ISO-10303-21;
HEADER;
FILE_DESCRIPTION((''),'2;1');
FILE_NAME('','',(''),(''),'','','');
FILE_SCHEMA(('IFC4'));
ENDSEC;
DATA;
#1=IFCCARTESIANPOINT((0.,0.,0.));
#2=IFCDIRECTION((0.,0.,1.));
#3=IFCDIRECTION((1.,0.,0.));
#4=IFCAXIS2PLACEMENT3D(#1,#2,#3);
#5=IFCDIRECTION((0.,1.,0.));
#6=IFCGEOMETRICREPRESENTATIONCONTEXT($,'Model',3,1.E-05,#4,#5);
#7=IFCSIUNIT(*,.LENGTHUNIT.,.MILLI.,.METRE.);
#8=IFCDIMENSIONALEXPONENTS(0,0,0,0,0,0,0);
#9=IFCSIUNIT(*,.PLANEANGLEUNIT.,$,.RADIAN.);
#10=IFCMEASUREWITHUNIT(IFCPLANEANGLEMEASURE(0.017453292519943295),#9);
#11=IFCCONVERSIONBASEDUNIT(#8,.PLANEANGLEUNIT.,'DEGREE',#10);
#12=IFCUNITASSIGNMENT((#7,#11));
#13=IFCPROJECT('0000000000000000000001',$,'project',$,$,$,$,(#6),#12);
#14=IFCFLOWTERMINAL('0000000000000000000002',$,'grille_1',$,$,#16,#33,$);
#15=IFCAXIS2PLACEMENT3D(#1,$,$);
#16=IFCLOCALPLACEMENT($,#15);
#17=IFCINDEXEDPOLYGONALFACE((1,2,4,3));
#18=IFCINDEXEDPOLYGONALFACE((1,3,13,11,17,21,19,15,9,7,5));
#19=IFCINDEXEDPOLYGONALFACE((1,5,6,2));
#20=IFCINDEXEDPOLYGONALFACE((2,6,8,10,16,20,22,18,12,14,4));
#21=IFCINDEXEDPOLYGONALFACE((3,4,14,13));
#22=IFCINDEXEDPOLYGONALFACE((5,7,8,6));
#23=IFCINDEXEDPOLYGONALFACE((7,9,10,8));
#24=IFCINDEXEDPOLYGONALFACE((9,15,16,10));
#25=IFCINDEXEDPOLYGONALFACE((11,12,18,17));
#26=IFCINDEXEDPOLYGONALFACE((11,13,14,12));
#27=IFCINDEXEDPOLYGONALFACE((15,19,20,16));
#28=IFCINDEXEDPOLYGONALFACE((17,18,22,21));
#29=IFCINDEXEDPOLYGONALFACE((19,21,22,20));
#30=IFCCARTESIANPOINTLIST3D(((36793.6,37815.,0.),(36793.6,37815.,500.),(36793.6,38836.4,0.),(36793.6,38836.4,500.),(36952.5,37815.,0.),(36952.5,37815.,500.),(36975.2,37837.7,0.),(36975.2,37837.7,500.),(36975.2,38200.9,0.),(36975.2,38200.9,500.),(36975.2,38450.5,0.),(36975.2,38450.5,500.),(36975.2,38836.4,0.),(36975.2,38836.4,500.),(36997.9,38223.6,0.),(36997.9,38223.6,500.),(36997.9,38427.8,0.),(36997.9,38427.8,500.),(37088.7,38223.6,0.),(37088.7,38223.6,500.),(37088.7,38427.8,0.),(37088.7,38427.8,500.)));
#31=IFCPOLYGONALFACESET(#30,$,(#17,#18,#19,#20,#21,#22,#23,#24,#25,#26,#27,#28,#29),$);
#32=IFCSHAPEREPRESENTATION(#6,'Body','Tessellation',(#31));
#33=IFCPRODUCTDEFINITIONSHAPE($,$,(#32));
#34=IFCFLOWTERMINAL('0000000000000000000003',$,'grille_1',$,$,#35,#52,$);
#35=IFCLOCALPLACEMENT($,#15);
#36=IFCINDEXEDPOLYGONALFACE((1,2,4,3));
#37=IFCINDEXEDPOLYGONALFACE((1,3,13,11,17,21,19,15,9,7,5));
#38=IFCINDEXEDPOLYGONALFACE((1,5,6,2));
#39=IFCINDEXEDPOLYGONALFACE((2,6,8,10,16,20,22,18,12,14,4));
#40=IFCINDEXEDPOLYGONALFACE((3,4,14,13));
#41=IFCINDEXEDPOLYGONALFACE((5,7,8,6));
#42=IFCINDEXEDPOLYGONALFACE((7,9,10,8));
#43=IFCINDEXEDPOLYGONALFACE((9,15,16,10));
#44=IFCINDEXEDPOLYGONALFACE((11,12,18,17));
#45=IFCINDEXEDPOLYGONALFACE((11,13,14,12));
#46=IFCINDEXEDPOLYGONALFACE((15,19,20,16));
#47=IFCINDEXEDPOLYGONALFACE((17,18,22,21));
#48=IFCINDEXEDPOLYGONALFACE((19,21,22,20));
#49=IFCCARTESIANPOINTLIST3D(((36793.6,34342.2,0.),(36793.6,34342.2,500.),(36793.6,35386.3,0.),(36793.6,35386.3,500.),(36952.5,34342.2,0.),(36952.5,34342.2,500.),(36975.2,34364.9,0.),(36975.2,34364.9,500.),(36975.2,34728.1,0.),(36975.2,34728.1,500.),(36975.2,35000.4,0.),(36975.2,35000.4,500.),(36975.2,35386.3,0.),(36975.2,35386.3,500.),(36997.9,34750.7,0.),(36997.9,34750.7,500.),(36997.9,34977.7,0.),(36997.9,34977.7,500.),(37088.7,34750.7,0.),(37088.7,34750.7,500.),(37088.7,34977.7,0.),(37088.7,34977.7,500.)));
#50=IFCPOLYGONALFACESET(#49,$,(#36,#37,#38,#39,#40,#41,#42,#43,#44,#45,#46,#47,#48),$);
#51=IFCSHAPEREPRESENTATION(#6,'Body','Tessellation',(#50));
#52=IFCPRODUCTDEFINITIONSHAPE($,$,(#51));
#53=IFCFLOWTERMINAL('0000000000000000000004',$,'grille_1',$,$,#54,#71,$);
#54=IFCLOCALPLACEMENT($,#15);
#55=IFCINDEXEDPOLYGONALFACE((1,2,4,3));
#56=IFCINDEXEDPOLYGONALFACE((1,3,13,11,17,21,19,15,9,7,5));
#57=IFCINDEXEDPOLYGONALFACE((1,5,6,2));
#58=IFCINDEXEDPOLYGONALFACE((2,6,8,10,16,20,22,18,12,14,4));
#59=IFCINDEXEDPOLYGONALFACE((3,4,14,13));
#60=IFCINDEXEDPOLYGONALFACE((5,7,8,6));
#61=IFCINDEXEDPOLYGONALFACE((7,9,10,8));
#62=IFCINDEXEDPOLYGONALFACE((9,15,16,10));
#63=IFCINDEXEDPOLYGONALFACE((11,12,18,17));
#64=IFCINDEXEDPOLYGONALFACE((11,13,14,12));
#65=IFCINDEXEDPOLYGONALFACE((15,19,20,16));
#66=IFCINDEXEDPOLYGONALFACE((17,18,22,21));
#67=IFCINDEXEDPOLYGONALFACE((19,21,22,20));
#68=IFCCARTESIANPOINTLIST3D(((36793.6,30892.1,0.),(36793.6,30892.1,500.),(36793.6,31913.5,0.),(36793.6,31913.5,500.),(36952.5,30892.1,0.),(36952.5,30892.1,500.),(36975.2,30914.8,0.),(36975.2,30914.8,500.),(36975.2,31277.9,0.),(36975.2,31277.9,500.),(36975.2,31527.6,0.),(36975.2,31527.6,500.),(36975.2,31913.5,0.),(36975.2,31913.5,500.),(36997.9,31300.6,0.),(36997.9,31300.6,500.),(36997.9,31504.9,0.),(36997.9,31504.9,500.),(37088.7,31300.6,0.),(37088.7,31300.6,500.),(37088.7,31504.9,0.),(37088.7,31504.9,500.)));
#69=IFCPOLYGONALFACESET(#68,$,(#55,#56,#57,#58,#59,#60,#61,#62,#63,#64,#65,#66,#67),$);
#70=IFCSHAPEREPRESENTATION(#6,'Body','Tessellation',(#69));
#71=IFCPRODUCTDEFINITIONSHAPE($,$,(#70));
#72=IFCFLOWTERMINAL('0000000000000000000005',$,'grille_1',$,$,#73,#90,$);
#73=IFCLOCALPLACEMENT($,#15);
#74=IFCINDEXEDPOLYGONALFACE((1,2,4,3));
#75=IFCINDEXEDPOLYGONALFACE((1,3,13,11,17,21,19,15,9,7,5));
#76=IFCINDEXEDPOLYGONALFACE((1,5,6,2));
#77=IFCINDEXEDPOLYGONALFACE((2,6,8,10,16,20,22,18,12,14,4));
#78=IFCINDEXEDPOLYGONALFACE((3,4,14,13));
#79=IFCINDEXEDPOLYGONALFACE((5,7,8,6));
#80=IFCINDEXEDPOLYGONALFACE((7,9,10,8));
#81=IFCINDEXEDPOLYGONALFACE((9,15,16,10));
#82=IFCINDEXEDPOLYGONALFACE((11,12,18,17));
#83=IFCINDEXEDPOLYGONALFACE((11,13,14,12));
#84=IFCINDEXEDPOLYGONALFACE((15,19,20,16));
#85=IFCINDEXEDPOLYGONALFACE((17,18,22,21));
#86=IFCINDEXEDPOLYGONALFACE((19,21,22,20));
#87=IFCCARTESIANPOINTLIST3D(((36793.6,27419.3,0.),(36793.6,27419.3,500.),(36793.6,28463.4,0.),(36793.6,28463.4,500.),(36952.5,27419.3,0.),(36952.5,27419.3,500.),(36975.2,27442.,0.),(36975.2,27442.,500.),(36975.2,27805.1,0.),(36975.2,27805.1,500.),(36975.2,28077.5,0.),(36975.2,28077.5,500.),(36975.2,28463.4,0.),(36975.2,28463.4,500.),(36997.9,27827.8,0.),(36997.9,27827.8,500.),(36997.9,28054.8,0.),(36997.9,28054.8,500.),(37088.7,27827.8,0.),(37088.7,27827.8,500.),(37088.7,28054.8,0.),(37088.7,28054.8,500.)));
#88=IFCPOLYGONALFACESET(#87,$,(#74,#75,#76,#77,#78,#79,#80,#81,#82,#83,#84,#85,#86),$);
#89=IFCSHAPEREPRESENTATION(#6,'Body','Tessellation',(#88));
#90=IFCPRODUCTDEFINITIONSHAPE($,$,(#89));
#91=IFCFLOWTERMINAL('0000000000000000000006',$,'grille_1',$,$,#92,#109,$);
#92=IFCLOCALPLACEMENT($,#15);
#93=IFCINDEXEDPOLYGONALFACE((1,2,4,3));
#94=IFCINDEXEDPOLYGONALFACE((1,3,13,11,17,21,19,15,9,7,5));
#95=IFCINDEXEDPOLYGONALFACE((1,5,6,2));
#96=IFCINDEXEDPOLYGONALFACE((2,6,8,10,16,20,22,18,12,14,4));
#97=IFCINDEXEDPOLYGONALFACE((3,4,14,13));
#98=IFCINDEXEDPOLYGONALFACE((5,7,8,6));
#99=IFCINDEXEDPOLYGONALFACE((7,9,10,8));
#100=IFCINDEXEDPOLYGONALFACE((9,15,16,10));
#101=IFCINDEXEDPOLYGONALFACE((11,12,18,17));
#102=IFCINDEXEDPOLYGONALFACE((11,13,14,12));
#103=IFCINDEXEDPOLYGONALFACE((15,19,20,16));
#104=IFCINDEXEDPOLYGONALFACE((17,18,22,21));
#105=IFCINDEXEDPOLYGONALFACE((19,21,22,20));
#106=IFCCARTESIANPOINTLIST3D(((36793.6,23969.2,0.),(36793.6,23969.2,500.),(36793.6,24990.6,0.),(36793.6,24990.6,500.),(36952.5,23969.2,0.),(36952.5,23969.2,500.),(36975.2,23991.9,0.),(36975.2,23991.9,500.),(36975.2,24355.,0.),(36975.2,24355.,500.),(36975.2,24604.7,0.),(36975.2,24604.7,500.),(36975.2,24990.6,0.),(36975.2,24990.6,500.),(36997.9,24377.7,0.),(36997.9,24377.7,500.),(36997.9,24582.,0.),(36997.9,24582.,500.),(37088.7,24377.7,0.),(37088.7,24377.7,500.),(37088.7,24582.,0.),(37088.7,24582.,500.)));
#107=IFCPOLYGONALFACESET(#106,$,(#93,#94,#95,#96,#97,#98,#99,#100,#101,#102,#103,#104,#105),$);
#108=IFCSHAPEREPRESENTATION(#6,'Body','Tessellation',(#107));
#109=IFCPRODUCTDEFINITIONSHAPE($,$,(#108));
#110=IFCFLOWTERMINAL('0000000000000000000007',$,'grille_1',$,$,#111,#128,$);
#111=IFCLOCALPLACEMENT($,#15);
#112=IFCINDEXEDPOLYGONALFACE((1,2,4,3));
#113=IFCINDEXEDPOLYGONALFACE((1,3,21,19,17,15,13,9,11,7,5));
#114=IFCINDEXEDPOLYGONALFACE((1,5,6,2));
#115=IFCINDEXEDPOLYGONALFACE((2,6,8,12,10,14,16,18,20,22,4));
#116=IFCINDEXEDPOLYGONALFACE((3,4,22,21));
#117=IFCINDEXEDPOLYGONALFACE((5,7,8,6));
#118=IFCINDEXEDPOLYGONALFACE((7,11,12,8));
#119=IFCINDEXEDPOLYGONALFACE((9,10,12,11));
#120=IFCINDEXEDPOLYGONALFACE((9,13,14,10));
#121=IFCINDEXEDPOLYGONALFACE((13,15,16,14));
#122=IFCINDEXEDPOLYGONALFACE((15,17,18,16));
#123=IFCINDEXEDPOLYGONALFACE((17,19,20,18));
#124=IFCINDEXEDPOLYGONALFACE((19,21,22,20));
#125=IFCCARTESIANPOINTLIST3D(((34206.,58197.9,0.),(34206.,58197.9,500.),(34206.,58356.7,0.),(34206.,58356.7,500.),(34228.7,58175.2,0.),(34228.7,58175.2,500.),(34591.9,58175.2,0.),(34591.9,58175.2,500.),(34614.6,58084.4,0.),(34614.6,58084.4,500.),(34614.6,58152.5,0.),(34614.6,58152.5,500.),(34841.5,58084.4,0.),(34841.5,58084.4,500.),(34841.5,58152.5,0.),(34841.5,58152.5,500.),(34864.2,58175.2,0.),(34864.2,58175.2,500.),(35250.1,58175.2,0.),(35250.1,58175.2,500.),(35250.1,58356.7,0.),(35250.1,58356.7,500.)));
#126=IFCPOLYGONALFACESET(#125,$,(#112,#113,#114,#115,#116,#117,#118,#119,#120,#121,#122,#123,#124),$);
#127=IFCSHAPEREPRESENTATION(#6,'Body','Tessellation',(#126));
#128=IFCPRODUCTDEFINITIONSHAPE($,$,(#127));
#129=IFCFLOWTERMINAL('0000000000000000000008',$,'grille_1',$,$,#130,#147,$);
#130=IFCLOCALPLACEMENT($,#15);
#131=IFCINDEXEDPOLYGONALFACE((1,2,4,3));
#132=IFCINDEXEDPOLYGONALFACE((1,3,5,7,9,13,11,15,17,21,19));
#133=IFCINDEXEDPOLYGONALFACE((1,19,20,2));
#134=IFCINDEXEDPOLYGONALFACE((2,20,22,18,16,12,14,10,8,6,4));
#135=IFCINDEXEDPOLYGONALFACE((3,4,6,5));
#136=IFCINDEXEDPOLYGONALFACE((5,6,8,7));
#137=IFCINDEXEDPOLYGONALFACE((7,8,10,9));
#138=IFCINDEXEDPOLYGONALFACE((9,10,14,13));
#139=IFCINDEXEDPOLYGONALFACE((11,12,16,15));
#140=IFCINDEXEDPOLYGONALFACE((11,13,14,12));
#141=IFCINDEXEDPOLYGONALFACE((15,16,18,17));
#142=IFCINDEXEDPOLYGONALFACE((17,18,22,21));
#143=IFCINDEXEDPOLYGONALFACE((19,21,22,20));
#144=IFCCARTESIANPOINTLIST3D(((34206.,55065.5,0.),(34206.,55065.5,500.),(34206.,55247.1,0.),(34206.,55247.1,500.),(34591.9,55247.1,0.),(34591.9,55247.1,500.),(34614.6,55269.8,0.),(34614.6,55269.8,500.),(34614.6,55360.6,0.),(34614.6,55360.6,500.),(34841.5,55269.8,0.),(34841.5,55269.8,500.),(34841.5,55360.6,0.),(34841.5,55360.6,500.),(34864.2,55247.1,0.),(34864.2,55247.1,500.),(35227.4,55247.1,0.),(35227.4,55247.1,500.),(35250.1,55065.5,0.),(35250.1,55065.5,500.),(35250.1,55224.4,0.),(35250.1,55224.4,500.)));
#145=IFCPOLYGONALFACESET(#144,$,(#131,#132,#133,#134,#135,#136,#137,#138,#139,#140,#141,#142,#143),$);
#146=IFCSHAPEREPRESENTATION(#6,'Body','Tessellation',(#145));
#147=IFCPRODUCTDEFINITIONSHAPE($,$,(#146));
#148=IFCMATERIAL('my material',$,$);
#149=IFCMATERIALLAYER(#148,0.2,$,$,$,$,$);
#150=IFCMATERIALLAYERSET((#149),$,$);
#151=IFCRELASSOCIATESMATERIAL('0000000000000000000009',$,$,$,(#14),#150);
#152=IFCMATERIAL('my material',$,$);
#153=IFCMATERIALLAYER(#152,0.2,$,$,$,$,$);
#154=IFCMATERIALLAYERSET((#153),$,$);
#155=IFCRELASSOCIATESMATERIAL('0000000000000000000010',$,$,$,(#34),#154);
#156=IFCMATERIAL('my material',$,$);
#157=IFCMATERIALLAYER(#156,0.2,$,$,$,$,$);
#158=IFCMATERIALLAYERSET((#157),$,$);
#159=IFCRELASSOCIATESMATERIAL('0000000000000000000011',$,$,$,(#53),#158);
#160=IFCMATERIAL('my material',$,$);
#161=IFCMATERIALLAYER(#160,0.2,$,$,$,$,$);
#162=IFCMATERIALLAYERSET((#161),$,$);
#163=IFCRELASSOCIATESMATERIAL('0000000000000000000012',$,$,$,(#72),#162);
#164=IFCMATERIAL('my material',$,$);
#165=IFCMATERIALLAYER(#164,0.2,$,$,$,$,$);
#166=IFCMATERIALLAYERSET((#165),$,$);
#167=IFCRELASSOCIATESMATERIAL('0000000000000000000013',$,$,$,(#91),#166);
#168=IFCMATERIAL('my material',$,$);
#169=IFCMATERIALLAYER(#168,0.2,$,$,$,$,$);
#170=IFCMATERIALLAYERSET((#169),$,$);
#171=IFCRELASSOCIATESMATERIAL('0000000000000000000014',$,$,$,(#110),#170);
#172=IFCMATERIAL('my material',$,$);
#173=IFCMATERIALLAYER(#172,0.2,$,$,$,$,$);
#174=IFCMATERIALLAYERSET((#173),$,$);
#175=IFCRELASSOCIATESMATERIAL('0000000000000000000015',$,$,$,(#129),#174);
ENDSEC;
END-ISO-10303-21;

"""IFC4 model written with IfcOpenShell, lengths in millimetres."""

from ifc_helpers import new_model, entity, si_unit, converted_unit, direction, origin_with_axes, place, context, project, polyline, outline, extrude, material, layer, layer_set, layer_usage, element, save


model = new_model("IFC4")

# Units and contexts
model_context = context("Model", 3, precision=1e-05, world=origin_with_axes(), true_north=direction((0.0, 1.0, 0.0)))
ifc_project = project(units=[si_unit("LENGTHUNIT", "METRE", prefix="MILLI"), converted_unit("PLANEANGLEUNIT", "DEGREE", entity("IfcPlaneAngleMeasure", 0.017453292519943295), si_unit("PLANEANGLEUNIT", "RADIAN"), dimensions=[0, 0, 0, 0, 0, 0, 0])], contexts=[model_context])

# Flow terminals
ifc_material_1 = material(Name="my material")
ifc_layer_1 = layer(ifc_material_1, 0.2)
ifc_layer_set_1 = layer_set([ifc_layer_1])
ifc_layer_usage_1 = layer_usage(ifc_layer_set_1, "AXIS2", "POSITIVE", -0.1)
flow_terminal_1_placement = place(None, origin_with_axes())
element("IfcFlowTerminal", 1, at=flow_terminal_1_placement, material=ifc_layer_usage_1, Name="grille_1", context=model_context, shape_type="SweptSolid", body=[
    extrude(outline(polyline([(36793.6, 37815.0), (36952.5, 37815.0), (36975.2, 37837.7), (36975.2, 38200.9), (36997.9, 38223.6), (37088.7, 38223.6), (37088.7, 38427.8), (36997.9, 38427.8), (36975.2, 38450.5), (36975.2, 38836.4), (36793.6, 38836.4), (36793.6, 37815.0)])), origin_with_axes(), (0.0, 0.0, 1.0), 500.0),
])
ifc_material_2 = material(Name="my material")
ifc_layer_2 = layer(ifc_material_2, 0.2)
ifc_layer_set_2 = layer_set([ifc_layer_2])
ifc_layer_usage_2 = layer_usage(ifc_layer_set_2, "AXIS2", "POSITIVE", -0.1)
flow_terminal_2_placement = place(None, origin_with_axes())
element("IfcFlowTerminal", 2, at=flow_terminal_2_placement, material=ifc_layer_usage_2, Name="grille_1", context=model_context, shape_type="SweptSolid", body=[
    extrude(outline(polyline([(36793.6, 34342.2), (36952.5, 34342.2), (36975.2, 34364.9), (36975.2, 34728.1), (36997.9, 34750.7), (37088.7, 34750.7), (37088.7, 34977.7), (36997.9, 34977.7), (36975.2, 35000.4), (36975.2, 35386.3), (36793.6, 35386.3), (36793.6, 34342.2)])), origin_with_axes(), (0.0, 0.0, 1.0), 500.0),
])
ifc_material_3 = material(Name="my material")
ifc_layer_3 = layer(ifc_material_3, 0.2)
ifc_layer_set_3 = layer_set([ifc_layer_3])
ifc_layer_usage_3 = layer_usage(ifc_layer_set_3, "AXIS2", "POSITIVE", -0.1)
flow_terminal_3_placement = place(None, origin_with_axes())
element("IfcFlowTerminal", 3, at=flow_terminal_3_placement, material=ifc_layer_usage_3, Name="grille_1", context=model_context, shape_type="SweptSolid", body=[
    extrude(outline(polyline([(36793.6, 30892.1), (36952.5, 30892.1), (36975.2, 30914.8), (36975.2, 31277.9), (36997.9, 31300.6), (37088.7, 31300.6), (37088.7, 31504.9), (36997.9, 31504.9), (36975.2, 31527.6), (36975.2, 31913.5), (36793.6, 31913.5), (36793.6, 30892.1)])), origin_with_axes(), (0.0, 0.0, 1.0), 500.0),
])
ifc_material_4 = material(Name="my material")
ifc_layer_4 = layer(ifc_material_4, 0.2)
ifc_layer_set_4 = layer_set([ifc_layer_4])
ifc_layer_usage_4 = layer_usage(ifc_layer_set_4, "AXIS2", "POSITIVE", -0.1)
flow_terminal_4_placement = place(None, origin_with_axes())
element("IfcFlowTerminal", 4, at=flow_terminal_4_placement, material=ifc_layer_usage_4, Name="grille_1", context=model_context, shape_type="SweptSolid", body=[
    extrude(outline(polyline([(36793.6, 27419.3), (36952.5, 27419.3), (36975.2, 27442.0), (36975.2, 27805.1), (36997.9, 27827.8), (37088.7, 27827.8), (37088.7, 28054.8), (36997.9, 28054.8), (36975.2, 28077.5), (36975.2, 28463.4), (36793.6, 28463.4), (36793.6, 27419.3)])), origin_with_axes(), (0.0, 0.0, 1.0), 500.0),
])
ifc_material_5 = material(Name="my material")
ifc_layer_5 = layer(ifc_material_5, 0.2)
ifc_layer_set_5 = layer_set([ifc_layer_5])
ifc_layer_usage_5 = layer_usage(ifc_layer_set_5, "AXIS2", "POSITIVE", -0.1)
flow_terminal_5_placement = place(None, origin_with_axes())
element("IfcFlowTerminal", 5, at=flow_terminal_5_placement, material=ifc_layer_usage_5, Name="grille_1", context=model_context, shape_type="SweptSolid", body=[
    extrude(outline(polyline([(36793.6, 23969.2), (36952.5, 23969.2), (36975.2, 23991.9), (36975.2, 24355.0), (36997.9, 24377.7), (37088.7, 24377.7), (37088.7, 24582.0), (36997.9, 24582.0), (36975.2, 24604.7), (36975.2, 24990.6), (36793.6, 24990.6), (36793.6, 23969.2)])), origin_with_axes(), (0.0, 0.0, 1.0), 500.0),
])
ifc_material_6 = material(Name="my material")
ifc_layer_6 = layer(ifc_material_6, 0.2)
ifc_layer_set_6 = layer_set([ifc_layer_6])
ifc_layer_usage_6 = layer_usage(ifc_layer_set_6, "AXIS2", "POSITIVE", -0.1)
flow_terminal_6_placement = place(None, origin_with_axes())
element("IfcFlowTerminal", 6, at=flow_terminal_6_placement, material=ifc_layer_usage_6, Name="grille_1", context=model_context, shape_type="SweptSolid", body=[
    extrude(outline(polyline([(34206.0, 58197.9), (34228.7, 58175.2), (34591.9, 58175.2), (34614.6, 58152.5), (34614.6, 58084.4), (34841.5, 58084.4), (34841.5, 58152.5), (34864.2, 58175.2), (35250.1, 58175.2), (35250.1, 58356.7), (34206.0, 58356.7), (34206.0, 58197.9)])), origin_with_axes(), (0.0, 0.0, 1.0), 500.0),
])
ifc_material_7 = material(Name="my material")
ifc_layer_7 = layer(ifc_material_7, 0.2)
ifc_layer_set_7 = layer_set([ifc_layer_7])
ifc_layer_usage_7 = layer_usage(ifc_layer_set_7, "AXIS2", "POSITIVE", -0.1)
flow_terminal_7_placement = place(None, origin_with_axes())
element("IfcFlowTerminal", 7, at=flow_terminal_7_placement, material=ifc_layer_usage_7, Name="grille_1", context=model_context, shape_type="SweptSolid", body=[
    extrude(outline(polyline([(34206.0, 55065.5), (35250.1, 55065.5), (35250.1, 55224.4), (35227.4, 55247.1), (34864.2, 55247.1), (34841.5, 55269.8), (34841.5, 55360.6), (34614.6, 55360.6), (34614.6, 55269.8), (34591.9, 55247.1), (34206.0, 55247.1), (34206.0, 55065.5)])), origin_with_axes(), (0.0, 0.0, 1.0), 500.0),
])

save(model, "model.ifc")
